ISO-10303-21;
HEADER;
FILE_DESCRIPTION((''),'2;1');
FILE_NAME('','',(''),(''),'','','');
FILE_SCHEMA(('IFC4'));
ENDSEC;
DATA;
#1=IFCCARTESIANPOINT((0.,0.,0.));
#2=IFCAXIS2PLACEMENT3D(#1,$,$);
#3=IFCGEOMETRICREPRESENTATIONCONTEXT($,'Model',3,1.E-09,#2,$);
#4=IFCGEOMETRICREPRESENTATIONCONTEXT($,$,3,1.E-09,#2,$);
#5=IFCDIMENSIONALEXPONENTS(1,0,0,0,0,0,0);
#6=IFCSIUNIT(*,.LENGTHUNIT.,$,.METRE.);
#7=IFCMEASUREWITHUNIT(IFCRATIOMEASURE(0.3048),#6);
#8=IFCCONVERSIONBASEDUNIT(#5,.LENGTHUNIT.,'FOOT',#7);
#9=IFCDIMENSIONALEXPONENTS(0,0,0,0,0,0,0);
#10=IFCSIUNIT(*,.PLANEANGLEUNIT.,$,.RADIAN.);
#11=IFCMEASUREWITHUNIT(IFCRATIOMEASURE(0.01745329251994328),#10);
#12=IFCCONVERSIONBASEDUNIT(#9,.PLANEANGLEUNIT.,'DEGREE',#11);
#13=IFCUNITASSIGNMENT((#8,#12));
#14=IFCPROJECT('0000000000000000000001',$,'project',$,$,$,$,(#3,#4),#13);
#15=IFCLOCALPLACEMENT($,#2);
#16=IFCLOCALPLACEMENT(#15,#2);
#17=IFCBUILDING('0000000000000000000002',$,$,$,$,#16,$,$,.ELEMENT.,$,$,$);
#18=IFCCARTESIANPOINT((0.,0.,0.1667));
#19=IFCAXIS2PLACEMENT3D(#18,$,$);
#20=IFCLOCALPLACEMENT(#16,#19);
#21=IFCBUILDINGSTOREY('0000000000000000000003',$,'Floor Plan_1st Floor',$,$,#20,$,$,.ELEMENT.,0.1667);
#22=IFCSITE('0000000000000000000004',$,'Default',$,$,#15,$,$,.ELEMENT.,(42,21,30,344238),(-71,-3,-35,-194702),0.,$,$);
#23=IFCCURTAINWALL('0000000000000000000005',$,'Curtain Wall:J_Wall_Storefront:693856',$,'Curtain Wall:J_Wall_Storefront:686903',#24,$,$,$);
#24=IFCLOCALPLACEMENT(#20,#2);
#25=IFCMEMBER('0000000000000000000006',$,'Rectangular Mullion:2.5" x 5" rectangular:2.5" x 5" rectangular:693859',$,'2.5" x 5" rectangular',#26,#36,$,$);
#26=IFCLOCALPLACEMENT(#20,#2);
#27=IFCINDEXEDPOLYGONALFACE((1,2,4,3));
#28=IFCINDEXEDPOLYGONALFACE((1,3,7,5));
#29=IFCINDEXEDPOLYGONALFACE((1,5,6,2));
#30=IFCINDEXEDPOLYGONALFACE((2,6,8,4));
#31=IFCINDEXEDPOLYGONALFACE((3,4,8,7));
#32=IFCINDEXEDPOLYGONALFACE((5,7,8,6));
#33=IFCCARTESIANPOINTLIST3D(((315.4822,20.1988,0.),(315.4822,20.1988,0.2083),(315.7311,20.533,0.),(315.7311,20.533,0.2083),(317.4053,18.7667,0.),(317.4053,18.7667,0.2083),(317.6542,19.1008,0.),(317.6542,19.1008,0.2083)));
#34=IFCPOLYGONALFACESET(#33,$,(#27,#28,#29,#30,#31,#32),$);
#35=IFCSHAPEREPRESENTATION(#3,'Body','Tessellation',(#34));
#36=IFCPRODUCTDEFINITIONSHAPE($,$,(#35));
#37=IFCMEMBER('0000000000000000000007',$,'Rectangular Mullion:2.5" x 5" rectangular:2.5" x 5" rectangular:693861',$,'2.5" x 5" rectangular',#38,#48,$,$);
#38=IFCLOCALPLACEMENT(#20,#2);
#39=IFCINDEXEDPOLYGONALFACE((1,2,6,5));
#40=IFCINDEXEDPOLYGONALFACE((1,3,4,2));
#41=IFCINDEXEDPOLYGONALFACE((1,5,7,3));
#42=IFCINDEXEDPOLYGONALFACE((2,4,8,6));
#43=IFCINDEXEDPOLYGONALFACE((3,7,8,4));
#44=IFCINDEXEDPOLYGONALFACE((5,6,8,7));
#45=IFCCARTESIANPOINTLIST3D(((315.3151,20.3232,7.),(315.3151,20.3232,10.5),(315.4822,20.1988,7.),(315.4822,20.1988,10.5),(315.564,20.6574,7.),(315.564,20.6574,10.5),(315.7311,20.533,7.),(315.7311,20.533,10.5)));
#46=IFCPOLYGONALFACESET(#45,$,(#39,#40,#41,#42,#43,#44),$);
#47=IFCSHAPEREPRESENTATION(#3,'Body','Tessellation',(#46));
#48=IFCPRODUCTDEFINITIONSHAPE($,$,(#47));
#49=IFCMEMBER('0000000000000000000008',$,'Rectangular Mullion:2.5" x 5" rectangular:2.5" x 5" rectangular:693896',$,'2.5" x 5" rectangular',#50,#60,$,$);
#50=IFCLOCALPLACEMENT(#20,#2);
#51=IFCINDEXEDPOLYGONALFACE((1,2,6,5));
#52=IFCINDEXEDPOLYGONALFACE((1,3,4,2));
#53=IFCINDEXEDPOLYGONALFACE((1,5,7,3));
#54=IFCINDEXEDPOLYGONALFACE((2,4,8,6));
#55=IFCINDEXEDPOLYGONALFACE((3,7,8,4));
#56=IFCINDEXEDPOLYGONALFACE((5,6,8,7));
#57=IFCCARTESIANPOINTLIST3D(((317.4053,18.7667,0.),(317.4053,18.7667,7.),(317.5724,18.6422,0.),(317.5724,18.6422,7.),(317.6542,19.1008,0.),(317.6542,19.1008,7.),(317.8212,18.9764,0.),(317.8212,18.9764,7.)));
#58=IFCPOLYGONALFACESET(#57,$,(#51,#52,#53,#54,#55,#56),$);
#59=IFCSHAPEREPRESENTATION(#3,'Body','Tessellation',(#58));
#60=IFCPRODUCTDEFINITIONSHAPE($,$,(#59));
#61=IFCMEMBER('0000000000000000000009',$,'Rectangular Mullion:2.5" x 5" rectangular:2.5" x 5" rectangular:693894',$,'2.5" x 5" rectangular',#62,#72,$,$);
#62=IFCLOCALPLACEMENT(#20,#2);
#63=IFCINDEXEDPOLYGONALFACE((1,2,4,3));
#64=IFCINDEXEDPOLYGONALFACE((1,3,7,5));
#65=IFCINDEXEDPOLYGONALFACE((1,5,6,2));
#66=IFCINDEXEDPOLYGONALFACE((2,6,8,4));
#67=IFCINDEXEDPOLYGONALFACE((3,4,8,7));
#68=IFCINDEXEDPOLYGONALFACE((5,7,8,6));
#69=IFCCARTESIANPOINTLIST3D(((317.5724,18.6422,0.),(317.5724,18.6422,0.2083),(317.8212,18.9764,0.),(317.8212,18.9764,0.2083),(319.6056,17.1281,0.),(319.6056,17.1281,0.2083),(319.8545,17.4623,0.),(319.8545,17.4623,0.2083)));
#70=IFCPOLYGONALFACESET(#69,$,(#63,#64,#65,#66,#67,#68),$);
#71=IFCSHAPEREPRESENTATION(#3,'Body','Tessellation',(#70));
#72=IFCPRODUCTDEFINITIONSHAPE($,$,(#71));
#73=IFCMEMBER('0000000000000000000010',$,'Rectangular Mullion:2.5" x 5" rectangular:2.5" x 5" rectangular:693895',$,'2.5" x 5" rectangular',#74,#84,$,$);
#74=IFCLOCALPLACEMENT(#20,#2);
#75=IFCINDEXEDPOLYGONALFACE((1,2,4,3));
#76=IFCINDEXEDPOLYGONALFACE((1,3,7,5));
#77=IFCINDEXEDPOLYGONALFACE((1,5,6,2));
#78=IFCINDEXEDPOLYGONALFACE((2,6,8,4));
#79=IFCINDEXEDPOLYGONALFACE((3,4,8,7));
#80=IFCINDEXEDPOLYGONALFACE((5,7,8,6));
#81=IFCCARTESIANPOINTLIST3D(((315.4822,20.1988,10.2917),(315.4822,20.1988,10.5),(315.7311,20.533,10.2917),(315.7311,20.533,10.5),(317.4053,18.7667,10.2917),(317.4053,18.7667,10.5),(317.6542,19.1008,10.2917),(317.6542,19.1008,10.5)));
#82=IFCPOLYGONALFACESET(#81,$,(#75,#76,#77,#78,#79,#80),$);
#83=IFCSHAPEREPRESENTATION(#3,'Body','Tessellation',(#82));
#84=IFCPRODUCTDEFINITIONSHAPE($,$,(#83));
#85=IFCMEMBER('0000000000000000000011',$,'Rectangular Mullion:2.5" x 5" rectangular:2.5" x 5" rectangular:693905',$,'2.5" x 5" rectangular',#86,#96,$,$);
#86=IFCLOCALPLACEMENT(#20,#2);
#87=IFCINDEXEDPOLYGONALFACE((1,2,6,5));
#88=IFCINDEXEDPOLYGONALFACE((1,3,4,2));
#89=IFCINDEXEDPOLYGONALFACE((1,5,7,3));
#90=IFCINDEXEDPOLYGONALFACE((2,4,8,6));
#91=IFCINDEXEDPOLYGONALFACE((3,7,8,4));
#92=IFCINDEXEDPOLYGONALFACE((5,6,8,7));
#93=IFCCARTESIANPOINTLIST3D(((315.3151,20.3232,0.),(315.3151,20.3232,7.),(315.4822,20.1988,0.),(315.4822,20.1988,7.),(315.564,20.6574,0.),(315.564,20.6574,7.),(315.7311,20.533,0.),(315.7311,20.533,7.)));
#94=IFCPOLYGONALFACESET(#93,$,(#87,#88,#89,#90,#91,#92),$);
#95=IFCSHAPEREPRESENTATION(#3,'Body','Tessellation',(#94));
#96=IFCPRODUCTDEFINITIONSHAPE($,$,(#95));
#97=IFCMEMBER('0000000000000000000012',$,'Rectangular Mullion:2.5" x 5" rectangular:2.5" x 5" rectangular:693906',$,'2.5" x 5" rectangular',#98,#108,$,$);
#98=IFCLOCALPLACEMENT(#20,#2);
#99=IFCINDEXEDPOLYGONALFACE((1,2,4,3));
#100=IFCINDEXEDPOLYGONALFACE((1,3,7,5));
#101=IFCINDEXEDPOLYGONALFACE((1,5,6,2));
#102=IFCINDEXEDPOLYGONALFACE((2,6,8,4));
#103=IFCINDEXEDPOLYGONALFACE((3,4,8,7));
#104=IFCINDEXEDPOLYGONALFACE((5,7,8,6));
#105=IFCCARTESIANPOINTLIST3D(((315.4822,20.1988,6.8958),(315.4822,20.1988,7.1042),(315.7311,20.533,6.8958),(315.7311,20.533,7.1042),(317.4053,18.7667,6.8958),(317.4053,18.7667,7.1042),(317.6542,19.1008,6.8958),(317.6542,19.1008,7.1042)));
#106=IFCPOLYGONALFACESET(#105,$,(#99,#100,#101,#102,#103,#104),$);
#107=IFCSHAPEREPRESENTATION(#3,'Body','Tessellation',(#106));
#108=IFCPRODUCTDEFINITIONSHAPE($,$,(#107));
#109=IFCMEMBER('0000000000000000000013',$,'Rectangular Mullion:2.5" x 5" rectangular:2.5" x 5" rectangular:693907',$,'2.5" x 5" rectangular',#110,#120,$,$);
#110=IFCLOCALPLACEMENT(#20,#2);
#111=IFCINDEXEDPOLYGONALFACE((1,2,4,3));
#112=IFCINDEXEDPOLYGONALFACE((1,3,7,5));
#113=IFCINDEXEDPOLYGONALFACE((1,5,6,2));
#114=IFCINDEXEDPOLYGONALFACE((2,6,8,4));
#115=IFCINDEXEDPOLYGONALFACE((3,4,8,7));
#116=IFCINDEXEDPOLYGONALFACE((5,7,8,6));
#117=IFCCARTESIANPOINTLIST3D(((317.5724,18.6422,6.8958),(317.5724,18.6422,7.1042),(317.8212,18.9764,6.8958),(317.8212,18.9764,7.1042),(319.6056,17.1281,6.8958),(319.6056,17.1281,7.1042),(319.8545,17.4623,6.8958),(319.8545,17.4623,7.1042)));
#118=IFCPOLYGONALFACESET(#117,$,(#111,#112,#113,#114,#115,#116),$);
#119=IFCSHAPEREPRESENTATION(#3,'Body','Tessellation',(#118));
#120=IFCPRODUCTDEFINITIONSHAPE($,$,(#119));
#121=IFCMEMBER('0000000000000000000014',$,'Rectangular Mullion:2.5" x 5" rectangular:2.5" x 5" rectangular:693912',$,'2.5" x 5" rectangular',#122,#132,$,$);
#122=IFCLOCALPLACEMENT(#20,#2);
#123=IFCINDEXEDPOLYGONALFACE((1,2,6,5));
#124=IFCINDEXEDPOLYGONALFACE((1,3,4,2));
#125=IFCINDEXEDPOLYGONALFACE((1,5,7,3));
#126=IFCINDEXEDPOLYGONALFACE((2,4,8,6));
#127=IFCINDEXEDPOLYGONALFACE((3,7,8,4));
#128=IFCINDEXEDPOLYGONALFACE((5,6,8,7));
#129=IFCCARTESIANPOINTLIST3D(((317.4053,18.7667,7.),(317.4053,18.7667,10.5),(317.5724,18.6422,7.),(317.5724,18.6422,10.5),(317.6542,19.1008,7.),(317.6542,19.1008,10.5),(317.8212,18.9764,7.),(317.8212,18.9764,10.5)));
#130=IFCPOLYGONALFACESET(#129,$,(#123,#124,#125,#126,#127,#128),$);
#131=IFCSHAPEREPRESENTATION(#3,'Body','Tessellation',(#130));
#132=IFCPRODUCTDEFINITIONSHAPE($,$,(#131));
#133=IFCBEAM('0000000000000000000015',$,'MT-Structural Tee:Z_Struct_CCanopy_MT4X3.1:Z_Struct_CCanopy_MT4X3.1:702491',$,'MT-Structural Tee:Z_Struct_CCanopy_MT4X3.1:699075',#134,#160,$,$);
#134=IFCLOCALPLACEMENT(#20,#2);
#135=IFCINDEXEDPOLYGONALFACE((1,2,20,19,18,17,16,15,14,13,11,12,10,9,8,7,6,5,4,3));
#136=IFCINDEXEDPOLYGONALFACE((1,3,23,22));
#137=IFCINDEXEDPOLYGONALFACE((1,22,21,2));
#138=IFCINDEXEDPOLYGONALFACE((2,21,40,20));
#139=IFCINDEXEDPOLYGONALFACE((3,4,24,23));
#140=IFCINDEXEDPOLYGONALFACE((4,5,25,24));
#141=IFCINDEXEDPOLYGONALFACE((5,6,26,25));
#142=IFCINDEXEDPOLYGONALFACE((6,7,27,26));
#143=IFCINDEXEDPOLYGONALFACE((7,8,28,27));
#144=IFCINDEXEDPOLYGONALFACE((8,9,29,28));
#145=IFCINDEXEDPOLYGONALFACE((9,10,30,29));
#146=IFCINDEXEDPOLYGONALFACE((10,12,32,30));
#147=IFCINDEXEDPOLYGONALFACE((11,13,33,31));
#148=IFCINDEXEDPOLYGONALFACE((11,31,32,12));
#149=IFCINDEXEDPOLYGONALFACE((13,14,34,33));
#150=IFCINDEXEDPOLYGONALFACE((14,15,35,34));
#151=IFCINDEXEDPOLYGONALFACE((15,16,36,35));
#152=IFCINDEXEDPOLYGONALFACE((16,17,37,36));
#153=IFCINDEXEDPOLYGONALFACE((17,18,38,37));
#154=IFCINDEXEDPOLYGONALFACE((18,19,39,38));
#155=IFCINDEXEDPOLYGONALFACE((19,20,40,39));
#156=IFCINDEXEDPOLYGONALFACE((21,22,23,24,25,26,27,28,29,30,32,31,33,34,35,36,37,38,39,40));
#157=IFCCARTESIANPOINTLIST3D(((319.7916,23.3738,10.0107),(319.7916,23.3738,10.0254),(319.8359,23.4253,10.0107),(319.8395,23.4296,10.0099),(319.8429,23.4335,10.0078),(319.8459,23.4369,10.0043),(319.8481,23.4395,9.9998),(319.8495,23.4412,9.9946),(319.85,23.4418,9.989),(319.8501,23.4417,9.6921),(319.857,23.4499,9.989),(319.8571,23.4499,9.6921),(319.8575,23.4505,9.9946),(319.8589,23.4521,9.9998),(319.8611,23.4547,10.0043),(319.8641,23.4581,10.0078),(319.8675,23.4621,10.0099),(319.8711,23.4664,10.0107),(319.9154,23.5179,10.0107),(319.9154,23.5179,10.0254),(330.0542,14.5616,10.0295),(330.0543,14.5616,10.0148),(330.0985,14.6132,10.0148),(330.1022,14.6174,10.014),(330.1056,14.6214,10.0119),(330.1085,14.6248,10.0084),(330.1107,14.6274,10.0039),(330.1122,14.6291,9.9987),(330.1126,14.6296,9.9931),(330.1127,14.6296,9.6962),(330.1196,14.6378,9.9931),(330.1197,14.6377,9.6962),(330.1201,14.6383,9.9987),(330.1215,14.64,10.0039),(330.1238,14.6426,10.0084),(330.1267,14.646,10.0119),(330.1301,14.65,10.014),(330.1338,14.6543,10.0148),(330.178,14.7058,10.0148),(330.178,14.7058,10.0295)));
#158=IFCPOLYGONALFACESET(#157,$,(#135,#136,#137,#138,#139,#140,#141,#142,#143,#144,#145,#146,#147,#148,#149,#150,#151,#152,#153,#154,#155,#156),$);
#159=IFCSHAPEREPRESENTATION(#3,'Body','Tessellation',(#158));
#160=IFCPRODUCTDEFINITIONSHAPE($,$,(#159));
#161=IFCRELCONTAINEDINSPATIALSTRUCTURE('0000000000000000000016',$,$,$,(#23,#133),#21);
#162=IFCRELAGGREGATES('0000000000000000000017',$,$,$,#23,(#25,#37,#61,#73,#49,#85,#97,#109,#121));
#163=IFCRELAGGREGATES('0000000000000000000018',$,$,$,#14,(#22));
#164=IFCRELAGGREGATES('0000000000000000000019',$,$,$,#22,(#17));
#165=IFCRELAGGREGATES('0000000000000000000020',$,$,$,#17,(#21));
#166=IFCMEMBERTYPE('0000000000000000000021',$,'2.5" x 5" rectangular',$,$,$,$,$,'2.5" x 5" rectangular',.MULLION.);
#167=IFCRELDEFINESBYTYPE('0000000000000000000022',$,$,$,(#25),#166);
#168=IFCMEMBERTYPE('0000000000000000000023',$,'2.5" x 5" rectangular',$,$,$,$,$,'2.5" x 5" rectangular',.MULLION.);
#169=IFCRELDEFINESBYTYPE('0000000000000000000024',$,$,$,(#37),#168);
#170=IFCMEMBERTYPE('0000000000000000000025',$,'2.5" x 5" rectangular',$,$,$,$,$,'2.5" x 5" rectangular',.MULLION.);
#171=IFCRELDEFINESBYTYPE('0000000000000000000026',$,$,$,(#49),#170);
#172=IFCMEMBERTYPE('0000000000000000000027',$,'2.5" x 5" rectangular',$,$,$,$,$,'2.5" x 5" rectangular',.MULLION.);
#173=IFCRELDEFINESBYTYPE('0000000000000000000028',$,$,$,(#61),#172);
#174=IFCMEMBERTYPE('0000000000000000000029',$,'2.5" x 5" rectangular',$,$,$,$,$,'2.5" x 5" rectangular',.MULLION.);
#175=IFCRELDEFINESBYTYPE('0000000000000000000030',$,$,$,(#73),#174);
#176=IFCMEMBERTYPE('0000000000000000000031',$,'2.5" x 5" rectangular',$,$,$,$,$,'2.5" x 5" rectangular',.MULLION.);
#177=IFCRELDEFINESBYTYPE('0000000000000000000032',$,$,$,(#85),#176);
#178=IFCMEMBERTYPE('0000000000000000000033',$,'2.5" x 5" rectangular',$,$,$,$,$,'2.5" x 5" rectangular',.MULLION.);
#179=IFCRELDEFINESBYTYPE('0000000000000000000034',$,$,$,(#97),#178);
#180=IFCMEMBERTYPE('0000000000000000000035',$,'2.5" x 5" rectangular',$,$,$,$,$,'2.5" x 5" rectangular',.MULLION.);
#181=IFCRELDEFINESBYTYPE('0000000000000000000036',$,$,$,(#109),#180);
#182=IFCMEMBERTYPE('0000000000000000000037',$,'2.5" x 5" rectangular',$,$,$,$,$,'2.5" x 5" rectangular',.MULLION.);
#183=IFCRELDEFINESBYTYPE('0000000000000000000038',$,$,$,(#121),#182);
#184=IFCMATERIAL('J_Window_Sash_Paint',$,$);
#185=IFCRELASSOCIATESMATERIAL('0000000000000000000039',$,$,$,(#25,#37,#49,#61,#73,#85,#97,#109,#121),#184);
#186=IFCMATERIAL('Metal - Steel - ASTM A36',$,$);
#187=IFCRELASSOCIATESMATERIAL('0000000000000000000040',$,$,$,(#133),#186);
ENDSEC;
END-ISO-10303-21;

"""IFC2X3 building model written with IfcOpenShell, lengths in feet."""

from ifc_helpers import new_model, entity, si_unit, converted_unit, frame, frame_2d, origin, origin_2d_with_axis, place, context, project, spatial, polyline, circle_curve, parameter, trimmed, segment, composite_curve, rectangle, outline, extrude, source, transform, mapped, material, type_object, type_shapes, element, aggregate, save


model = new_model("IFC2X3")

# Units and contexts
model_context = context("Model", 3, precision=1e-09, world=origin())
context_of_model = context(None, 3, precision=1e-09, world=origin())
ifc_project = project(units=[converted_unit("LENGTHUNIT", "FOOT", entity("IfcRatioMeasure", 0.3048), si_unit("LENGTHUNIT", "METRE"), dimensions=[1, 0, 0, 0, 0, 0, 0]), converted_unit("PLANEANGLEUNIT", "DEGREE", entity("IfcRatioMeasure", 0.01745329251994328), si_unit("PLANEANGLEUNIT", "RADIAN"), dimensions=[0, 0, 0, 0, 0, 0, 0])], contexts=[model_context, context_of_model])

# Site, building, storey
site_placement = place(None, origin())
site = spatial("IfcSite", under=ifc_project, at=site_placement, Name="Default", CompositionType="ELEMENT", RefLatitude=(42, 21, 30, 344238), RefLongitude=(-71, -3, -35, -194702), RefElevation=0.0)
building_placement = place(site_placement, origin())
building = spatial("IfcBuilding", under=site, at=building_placement, CompositionType="ELEMENT")
storey_placement = place(building_placement, frame((0.0, 0.0, 0.1667)))
storey = spatial("IfcBuildingStorey", under=building, at=storey_placement, Name="Floor Plan_1st Floor", CompositionType="ELEMENT", Elevation=0.1667)

# Curtain wall, members
curtain_wall_placement = place(storey_placement, origin())
curtain_wall = element("IfcCurtainWall", 1, at=curtain_wall_placement, inside=storey, Name="Curtain Wall:J_Wall_Storefront:693856", ObjectType="Curtain Wall:J_Wall_Storefront:686903")
ifc_material_1 = material(Name="J_Window_Sash_Paint")
member_type_1 = type_object("IfcMemberType", Name="2.5\" x 5\" rectangular", ElementType="2.5\" x 5\" rectangular", PredefinedType="MULLION")
shared_shape_1 = source(origin(), model_context, "Body", "SweptSolid", [
    extrude(rectangle(XDim=0.2083, YDim=0.4167, at=origin_2d_with_axis()), frame((-0.1042, 0.0, -2.3978), z_axis=(0.0, 0.0, 1.0), x_axis=(-1.0, 0.0, 0.0)), (0.0, 0.0, 1.0), 2.3978),
])
type_shapes(member_type_1, [shared_shape_1])
member_1_placement = place(storey_placement, frame((315.6066, 20.3659, 0.0), z_axis=(-0.802039, 0.597272, 0.0), x_axis=(0.0, 0.0, -1.0)))
member_1 = element("IfcMember", 2, at=member_1_placement, type_object=member_type_1, material=ifc_material_1, Name="Rectangular Mullion:2.5\" x 5\" rectangular:2.5\" x 5\" rectangular:693859", ObjectType="2.5\" x 5\" rectangular", context=model_context, shape_type="MappedRepresentation", body=[
    mapped(shared_shape_1, transform((0.0, 0.0, 0.0), scale=1.0)),
])
member_type_2 = type_object("IfcMemberType", Name="2.5\" x 5\" rectangular", ElementType="2.5\" x 5\" rectangular", PredefinedType="MULLION")
shared_shape_2 = source(origin(), model_context, "Body", "SweptSolid", [
    extrude(rectangle(XDim=0.2083, YDim=0.4167, at=origin_2d_with_axis()), frame((-0.1042, 0.0, -3.5), z_axis=(0.0, 0.0, 1.0), x_axis=(-1.0, 0.0, 0.0)), (0.0, 0.0, 1.0), 3.5),
])
type_shapes(member_type_2, [shared_shape_2])
member_2_placement = place(storey_placement, frame((315.4395, 20.4903, 10.5), z_axis=(0.0, 0.0, 1.0), x_axis=(-0.802039, 0.597272, 0.0)))
member_2 = element("IfcMember", 3, at=member_2_placement, type_object=member_type_2, material=ifc_material_1, Name="Rectangular Mullion:2.5\" x 5\" rectangular:2.5\" x 5\" rectangular:693861", ObjectType="2.5\" x 5\" rectangular", context=model_context, shape_type="MappedRepresentation", body=[
    mapped(shared_shape_2, transform((0.0, 0.0, 0.0), scale=1.0)),
])
member_type_3 = type_object("IfcMemberType", Name="2.5\" x 5\" rectangular", ElementType="2.5\" x 5\" rectangular", PredefinedType="MULLION")
shared_shape_3 = source(origin(), model_context, "Body", "SweptSolid", [
    extrude(rectangle(XDim=0.2083, YDim=0.4167, at=origin_2d_with_axis()), frame((0.0, 0.0, -7.0), z_axis=(0.0, 0.0, 1.0), x_axis=(-1.0, 0.0, 0.0)), (0.0, 0.0, 1.0), 7.0),
])
type_shapes(member_type_3, [shared_shape_3])
member_3_placement = place(storey_placement, frame((317.6133, 18.8715, 0.0), z_axis=(0.0, 0.0, -1.0), x_axis=(0.802039, -0.597272, 0.0)))
member_3 = element("IfcMember", 4, at=member_3_placement, type_object=member_type_3, material=ifc_material_1, Name="Rectangular Mullion:2.5\" x 5\" rectangular:2.5\" x 5\" rectangular:693896", ObjectType="2.5\" x 5\" rectangular", context=model_context, shape_type="MappedRepresentation", body=[
    mapped(shared_shape_3, transform((0.0, 0.0, 0.0), scale=1.0)),
])
member_type_4 = type_object("IfcMemberType", Name="2.5\" x 5\" rectangular", ElementType="2.5\" x 5\" rectangular", PredefinedType="MULLION")
shared_shape_4 = source(origin(), model_context, "Body", "SweptSolid", [
    extrude(rectangle(XDim=0.2083, YDim=0.4167, at=origin_2d_with_axis()), frame((-0.1042, 0.0, -2.5351), z_axis=(0.0, 0.0, 1.0), x_axis=(-1.0, 0.0, 0.0)), (0.0, 0.0, 1.0), 2.5351),
])
type_shapes(member_type_4, [shared_shape_4])
member_4_placement = place(storey_placement, frame((317.6968, 18.8093, 0.0), z_axis=(-0.802039, 0.597272, 0.0), x_axis=(0.0, 0.0, -1.0)))
member_4 = element("IfcMember", 5, at=member_4_placement, type_object=member_type_4, material=ifc_material_1, Name="Rectangular Mullion:2.5\" x 5\" rectangular:2.5\" x 5\" rectangular:693894", ObjectType="2.5\" x 5\" rectangular", context=model_context, shape_type="MappedRepresentation", body=[
    mapped(shared_shape_4, transform((0.0, 0.0, 0.0), scale=1.0)),
])
member_type_5 = type_object("IfcMemberType", Name="2.5\" x 5\" rectangular", ElementType="2.5\" x 5\" rectangular", PredefinedType="MULLION")
shared_shape_5 = source(origin(), model_context, "Body", "SweptSolid", [
    extrude(rectangle(XDim=0.2083, YDim=0.4167, at=origin_2d_with_axis()), frame((-0.1042, 0.0, -2.3978), z_axis=(0.0, 0.0, 1.0), x_axis=(-1.0, 0.0, 0.0)), (0.0, 0.0, 1.0), 2.3978),
])
type_shapes(member_type_5, [shared_shape_5])
member_5_placement = place(storey_placement, frame((317.5297, 18.9338, 10.5), z_axis=(0.802039, -0.597272, 0.0), x_axis=(0.0, 0.0, 1.0)))
member_5 = element("IfcMember", 6, at=member_5_placement, type_object=member_type_5, material=ifc_material_1, Name="Rectangular Mullion:2.5\" x 5\" rectangular:2.5\" x 5\" rectangular:693895", ObjectType="2.5\" x 5\" rectangular", context=model_context, shape_type="MappedRepresentation", body=[
    mapped(shared_shape_5, transform((0.0, 0.0, 0.0), scale=1.0)),
])
member_type_6 = type_object("IfcMemberType", Name="2.5\" x 5\" rectangular", ElementType="2.5\" x 5\" rectangular", PredefinedType="MULLION")
shared_shape_6 = source(origin(), model_context, "Body", "SweptSolid", [
    extrude(rectangle(XDim=0.2083, YDim=0.4167, at=origin_2d_with_axis()), frame((-0.1042, 0.0, -7.0), z_axis=(0.0, 0.0, 1.0), x_axis=(-1.0, 0.0, 0.0)), (0.0, 0.0, 1.0), 7.0),
])
type_shapes(member_type_6, [shared_shape_6])
member_6_placement = place(storey_placement, frame((315.4395, 20.4903, 7.0), z_axis=(0.0, 0.0, 1.0), x_axis=(-0.802039, 0.597272, 0.0)))
member_6 = element("IfcMember", 7, at=member_6_placement, type_object=member_type_6, material=ifc_material_1, Name="Rectangular Mullion:2.5\" x 5\" rectangular:2.5\" x 5\" rectangular:693905", ObjectType="2.5\" x 5\" rectangular", context=model_context, shape_type="MappedRepresentation", body=[
    mapped(shared_shape_6, transform((0.0, 0.0, 0.0), scale=1.0)),
])
member_type_7 = type_object("IfcMemberType", Name="2.5\" x 5\" rectangular", ElementType="2.5\" x 5\" rectangular", PredefinedType="MULLION")
shared_shape_7 = source(origin(), model_context, "Body", "SweptSolid", [
    extrude(rectangle(XDim=0.2083, YDim=0.4167, at=origin_2d_with_axis()), frame((0.0, 0.0, -2.3978), z_axis=(0.0, 0.0, 1.0), x_axis=(-1.0, 0.0, 0.0)), (0.0, 0.0, 1.0), 2.3978),
])
type_shapes(member_type_7, [shared_shape_7])
member_7_placement = place(storey_placement, frame((317.5297, 18.9338, 7.0), z_axis=(0.802039, -0.597272, 0.0), x_axis=(0.0, 0.0, 1.0)))
member_7 = element("IfcMember", 8, at=member_7_placement, type_object=member_type_7, material=ifc_material_1, Name="Rectangular Mullion:2.5\" x 5\" rectangular:2.5\" x 5\" rectangular:693906", ObjectType="2.5\" x 5\" rectangular", context=model_context, shape_type="MappedRepresentation", body=[
    mapped(shared_shape_7, transform((0.0, 0.0, 0.0), scale=1.0)),
])
member_type_8 = type_object("IfcMemberType", Name="2.5\" x 5\" rectangular", ElementType="2.5\" x 5\" rectangular", PredefinedType="MULLION")
shared_shape_8 = source(origin(), model_context, "Body", "SweptSolid", [
    extrude(rectangle(XDim=0.2083, YDim=0.4167, at=origin_2d_with_axis()), frame((0.0, 0.0, -2.5351), z_axis=(0.0, 0.0, 1.0), x_axis=(-1.0, 0.0, 0.0)), (0.0, 0.0, 1.0), 2.5351),
])
type_shapes(member_type_8, [shared_shape_8])
member_8_placement = place(storey_placement, frame((319.73, 17.2952, 7.0), z_axis=(0.802039, -0.597272, 0.0), x_axis=(0.0, 0.0, 1.0)))
member_8 = element("IfcMember", 9, at=member_8_placement, type_object=member_type_8, material=ifc_material_1, Name="Rectangular Mullion:2.5\" x 5\" rectangular:2.5\" x 5\" rectangular:693907", ObjectType="2.5\" x 5\" rectangular", context=model_context, shape_type="MappedRepresentation", body=[
    mapped(shared_shape_8, transform((0.0, 0.0, 0.0), scale=1.0)),
])
member_type_9 = type_object("IfcMemberType", Name="2.5\" x 5\" rectangular", ElementType="2.5\" x 5\" rectangular", PredefinedType="MULLION")
shared_shape_9 = source(origin(), model_context, "Body", "SweptSolid", [
    extrude(rectangle(XDim=0.2083, YDim=0.4167, at=origin_2d_with_axis()), frame((0.0, 0.0, -3.5), z_axis=(0.0, 0.0, 1.0), x_axis=(-1.0, 0.0, 0.0)), (0.0, 0.0, 1.0), 3.5),
])
type_shapes(member_type_9, [shared_shape_9])
member_9_placement = place(storey_placement, frame((317.6133, 18.8715, 7.0), z_axis=(0.0, 0.0, -1.0), x_axis=(0.802039, -0.597272, 0.0)))
member_9 = element("IfcMember", 10, at=member_9_placement, type_object=member_type_9, material=ifc_material_1, Name="Rectangular Mullion:2.5\" x 5\" rectangular:2.5\" x 5\" rectangular:693912", ObjectType="2.5\" x 5\" rectangular", context=model_context, shape_type="MappedRepresentation", body=[
    mapped(shared_shape_9, transform((0.0, 0.0, 0.0), scale=1.0)),
])

# Beam
ifc_material_2 = material(Name="Metal - Steel - ASTM A36")
beam_1_placement = place(storey_placement, frame((320.6249, 22.7835, 10.0257), z_axis=(-0.000231, 0.000198, 1.0), x_axis=(-0.651455, -0.758687, 0.0)))
element("IfcBeam", 11, at=beam_1_placement, inside=storey, material=ifc_material_2, Name="MT-Structural Tee:Z_Struct_CCanopy_MT4X3.1:Z_Struct_CCanopy_MT4X3.1:702491", ObjectType="MT-Structural Tee:Z_Struct_CCanopy_MT4X3.1:699075", context=model_context, shape_type="SweptSolid", body=[
    extrude(outline(composite_curve([segment(polyline([(-0.0799, -0.095), (-0.0651, -0.095)]), True, "CONTINUOUS"), segment(polyline([(-0.0651, -0.095), (-0.0651, -0.0271)]), True, "CONTINUOUS"), segment(trimmed(circle_curve(frame_2d((-0.0434, -0.0271), x_axis=(0.0, -1.0)), 0.0217), [parameter(180.0)], [parameter(270.0)], True, "PARAMETER"), False, "CONTINUOUS"), segment(polyline([(-0.0434, -0.0054), (0.2535, -0.0054)]), True, "CONTINUOUS"), segment(polyline([(0.2535, -0.0054), (0.2535, 0.0054)]), True, "CONTINUOUS"), segment(polyline([(0.2535, 0.0054), (-0.0434, 0.0054)]), True, "CONTINUOUS"), segment(trimmed(circle_curve(frame_2d((-0.0434, 0.0271), x_axis=(0.0, -1.0)), 0.0217), [parameter(270.0)], [parameter(0.0)], True, "PARAMETER"), False, "CONTINUOUS"), segment(polyline([(-0.0651, 0.0271), (-0.0651, 0.095)]), True, "CONTINUOUS"), segment(polyline([(-0.0651, 0.095), (-0.0799, 0.095)]), True, "CONTINUOUS"), segment(polyline([(-0.0799, 0.095), (-0.0799, -0.095)]), True, "CONTINUOUS")], self_intersect=False)), frame((0.0, -1.0168, -0.0799), z_axis=(0.0, 1.0, 0.0), x_axis=(0.0, 0.0, -1.0)), (0.0, 0.0, 1.0), 13.5268),
])

aggregate(curtain_wall, [member_1, member_2, member_4, member_5, member_3, member_6, member_7, member_8, member_9])

save(model, "model.ifc")
